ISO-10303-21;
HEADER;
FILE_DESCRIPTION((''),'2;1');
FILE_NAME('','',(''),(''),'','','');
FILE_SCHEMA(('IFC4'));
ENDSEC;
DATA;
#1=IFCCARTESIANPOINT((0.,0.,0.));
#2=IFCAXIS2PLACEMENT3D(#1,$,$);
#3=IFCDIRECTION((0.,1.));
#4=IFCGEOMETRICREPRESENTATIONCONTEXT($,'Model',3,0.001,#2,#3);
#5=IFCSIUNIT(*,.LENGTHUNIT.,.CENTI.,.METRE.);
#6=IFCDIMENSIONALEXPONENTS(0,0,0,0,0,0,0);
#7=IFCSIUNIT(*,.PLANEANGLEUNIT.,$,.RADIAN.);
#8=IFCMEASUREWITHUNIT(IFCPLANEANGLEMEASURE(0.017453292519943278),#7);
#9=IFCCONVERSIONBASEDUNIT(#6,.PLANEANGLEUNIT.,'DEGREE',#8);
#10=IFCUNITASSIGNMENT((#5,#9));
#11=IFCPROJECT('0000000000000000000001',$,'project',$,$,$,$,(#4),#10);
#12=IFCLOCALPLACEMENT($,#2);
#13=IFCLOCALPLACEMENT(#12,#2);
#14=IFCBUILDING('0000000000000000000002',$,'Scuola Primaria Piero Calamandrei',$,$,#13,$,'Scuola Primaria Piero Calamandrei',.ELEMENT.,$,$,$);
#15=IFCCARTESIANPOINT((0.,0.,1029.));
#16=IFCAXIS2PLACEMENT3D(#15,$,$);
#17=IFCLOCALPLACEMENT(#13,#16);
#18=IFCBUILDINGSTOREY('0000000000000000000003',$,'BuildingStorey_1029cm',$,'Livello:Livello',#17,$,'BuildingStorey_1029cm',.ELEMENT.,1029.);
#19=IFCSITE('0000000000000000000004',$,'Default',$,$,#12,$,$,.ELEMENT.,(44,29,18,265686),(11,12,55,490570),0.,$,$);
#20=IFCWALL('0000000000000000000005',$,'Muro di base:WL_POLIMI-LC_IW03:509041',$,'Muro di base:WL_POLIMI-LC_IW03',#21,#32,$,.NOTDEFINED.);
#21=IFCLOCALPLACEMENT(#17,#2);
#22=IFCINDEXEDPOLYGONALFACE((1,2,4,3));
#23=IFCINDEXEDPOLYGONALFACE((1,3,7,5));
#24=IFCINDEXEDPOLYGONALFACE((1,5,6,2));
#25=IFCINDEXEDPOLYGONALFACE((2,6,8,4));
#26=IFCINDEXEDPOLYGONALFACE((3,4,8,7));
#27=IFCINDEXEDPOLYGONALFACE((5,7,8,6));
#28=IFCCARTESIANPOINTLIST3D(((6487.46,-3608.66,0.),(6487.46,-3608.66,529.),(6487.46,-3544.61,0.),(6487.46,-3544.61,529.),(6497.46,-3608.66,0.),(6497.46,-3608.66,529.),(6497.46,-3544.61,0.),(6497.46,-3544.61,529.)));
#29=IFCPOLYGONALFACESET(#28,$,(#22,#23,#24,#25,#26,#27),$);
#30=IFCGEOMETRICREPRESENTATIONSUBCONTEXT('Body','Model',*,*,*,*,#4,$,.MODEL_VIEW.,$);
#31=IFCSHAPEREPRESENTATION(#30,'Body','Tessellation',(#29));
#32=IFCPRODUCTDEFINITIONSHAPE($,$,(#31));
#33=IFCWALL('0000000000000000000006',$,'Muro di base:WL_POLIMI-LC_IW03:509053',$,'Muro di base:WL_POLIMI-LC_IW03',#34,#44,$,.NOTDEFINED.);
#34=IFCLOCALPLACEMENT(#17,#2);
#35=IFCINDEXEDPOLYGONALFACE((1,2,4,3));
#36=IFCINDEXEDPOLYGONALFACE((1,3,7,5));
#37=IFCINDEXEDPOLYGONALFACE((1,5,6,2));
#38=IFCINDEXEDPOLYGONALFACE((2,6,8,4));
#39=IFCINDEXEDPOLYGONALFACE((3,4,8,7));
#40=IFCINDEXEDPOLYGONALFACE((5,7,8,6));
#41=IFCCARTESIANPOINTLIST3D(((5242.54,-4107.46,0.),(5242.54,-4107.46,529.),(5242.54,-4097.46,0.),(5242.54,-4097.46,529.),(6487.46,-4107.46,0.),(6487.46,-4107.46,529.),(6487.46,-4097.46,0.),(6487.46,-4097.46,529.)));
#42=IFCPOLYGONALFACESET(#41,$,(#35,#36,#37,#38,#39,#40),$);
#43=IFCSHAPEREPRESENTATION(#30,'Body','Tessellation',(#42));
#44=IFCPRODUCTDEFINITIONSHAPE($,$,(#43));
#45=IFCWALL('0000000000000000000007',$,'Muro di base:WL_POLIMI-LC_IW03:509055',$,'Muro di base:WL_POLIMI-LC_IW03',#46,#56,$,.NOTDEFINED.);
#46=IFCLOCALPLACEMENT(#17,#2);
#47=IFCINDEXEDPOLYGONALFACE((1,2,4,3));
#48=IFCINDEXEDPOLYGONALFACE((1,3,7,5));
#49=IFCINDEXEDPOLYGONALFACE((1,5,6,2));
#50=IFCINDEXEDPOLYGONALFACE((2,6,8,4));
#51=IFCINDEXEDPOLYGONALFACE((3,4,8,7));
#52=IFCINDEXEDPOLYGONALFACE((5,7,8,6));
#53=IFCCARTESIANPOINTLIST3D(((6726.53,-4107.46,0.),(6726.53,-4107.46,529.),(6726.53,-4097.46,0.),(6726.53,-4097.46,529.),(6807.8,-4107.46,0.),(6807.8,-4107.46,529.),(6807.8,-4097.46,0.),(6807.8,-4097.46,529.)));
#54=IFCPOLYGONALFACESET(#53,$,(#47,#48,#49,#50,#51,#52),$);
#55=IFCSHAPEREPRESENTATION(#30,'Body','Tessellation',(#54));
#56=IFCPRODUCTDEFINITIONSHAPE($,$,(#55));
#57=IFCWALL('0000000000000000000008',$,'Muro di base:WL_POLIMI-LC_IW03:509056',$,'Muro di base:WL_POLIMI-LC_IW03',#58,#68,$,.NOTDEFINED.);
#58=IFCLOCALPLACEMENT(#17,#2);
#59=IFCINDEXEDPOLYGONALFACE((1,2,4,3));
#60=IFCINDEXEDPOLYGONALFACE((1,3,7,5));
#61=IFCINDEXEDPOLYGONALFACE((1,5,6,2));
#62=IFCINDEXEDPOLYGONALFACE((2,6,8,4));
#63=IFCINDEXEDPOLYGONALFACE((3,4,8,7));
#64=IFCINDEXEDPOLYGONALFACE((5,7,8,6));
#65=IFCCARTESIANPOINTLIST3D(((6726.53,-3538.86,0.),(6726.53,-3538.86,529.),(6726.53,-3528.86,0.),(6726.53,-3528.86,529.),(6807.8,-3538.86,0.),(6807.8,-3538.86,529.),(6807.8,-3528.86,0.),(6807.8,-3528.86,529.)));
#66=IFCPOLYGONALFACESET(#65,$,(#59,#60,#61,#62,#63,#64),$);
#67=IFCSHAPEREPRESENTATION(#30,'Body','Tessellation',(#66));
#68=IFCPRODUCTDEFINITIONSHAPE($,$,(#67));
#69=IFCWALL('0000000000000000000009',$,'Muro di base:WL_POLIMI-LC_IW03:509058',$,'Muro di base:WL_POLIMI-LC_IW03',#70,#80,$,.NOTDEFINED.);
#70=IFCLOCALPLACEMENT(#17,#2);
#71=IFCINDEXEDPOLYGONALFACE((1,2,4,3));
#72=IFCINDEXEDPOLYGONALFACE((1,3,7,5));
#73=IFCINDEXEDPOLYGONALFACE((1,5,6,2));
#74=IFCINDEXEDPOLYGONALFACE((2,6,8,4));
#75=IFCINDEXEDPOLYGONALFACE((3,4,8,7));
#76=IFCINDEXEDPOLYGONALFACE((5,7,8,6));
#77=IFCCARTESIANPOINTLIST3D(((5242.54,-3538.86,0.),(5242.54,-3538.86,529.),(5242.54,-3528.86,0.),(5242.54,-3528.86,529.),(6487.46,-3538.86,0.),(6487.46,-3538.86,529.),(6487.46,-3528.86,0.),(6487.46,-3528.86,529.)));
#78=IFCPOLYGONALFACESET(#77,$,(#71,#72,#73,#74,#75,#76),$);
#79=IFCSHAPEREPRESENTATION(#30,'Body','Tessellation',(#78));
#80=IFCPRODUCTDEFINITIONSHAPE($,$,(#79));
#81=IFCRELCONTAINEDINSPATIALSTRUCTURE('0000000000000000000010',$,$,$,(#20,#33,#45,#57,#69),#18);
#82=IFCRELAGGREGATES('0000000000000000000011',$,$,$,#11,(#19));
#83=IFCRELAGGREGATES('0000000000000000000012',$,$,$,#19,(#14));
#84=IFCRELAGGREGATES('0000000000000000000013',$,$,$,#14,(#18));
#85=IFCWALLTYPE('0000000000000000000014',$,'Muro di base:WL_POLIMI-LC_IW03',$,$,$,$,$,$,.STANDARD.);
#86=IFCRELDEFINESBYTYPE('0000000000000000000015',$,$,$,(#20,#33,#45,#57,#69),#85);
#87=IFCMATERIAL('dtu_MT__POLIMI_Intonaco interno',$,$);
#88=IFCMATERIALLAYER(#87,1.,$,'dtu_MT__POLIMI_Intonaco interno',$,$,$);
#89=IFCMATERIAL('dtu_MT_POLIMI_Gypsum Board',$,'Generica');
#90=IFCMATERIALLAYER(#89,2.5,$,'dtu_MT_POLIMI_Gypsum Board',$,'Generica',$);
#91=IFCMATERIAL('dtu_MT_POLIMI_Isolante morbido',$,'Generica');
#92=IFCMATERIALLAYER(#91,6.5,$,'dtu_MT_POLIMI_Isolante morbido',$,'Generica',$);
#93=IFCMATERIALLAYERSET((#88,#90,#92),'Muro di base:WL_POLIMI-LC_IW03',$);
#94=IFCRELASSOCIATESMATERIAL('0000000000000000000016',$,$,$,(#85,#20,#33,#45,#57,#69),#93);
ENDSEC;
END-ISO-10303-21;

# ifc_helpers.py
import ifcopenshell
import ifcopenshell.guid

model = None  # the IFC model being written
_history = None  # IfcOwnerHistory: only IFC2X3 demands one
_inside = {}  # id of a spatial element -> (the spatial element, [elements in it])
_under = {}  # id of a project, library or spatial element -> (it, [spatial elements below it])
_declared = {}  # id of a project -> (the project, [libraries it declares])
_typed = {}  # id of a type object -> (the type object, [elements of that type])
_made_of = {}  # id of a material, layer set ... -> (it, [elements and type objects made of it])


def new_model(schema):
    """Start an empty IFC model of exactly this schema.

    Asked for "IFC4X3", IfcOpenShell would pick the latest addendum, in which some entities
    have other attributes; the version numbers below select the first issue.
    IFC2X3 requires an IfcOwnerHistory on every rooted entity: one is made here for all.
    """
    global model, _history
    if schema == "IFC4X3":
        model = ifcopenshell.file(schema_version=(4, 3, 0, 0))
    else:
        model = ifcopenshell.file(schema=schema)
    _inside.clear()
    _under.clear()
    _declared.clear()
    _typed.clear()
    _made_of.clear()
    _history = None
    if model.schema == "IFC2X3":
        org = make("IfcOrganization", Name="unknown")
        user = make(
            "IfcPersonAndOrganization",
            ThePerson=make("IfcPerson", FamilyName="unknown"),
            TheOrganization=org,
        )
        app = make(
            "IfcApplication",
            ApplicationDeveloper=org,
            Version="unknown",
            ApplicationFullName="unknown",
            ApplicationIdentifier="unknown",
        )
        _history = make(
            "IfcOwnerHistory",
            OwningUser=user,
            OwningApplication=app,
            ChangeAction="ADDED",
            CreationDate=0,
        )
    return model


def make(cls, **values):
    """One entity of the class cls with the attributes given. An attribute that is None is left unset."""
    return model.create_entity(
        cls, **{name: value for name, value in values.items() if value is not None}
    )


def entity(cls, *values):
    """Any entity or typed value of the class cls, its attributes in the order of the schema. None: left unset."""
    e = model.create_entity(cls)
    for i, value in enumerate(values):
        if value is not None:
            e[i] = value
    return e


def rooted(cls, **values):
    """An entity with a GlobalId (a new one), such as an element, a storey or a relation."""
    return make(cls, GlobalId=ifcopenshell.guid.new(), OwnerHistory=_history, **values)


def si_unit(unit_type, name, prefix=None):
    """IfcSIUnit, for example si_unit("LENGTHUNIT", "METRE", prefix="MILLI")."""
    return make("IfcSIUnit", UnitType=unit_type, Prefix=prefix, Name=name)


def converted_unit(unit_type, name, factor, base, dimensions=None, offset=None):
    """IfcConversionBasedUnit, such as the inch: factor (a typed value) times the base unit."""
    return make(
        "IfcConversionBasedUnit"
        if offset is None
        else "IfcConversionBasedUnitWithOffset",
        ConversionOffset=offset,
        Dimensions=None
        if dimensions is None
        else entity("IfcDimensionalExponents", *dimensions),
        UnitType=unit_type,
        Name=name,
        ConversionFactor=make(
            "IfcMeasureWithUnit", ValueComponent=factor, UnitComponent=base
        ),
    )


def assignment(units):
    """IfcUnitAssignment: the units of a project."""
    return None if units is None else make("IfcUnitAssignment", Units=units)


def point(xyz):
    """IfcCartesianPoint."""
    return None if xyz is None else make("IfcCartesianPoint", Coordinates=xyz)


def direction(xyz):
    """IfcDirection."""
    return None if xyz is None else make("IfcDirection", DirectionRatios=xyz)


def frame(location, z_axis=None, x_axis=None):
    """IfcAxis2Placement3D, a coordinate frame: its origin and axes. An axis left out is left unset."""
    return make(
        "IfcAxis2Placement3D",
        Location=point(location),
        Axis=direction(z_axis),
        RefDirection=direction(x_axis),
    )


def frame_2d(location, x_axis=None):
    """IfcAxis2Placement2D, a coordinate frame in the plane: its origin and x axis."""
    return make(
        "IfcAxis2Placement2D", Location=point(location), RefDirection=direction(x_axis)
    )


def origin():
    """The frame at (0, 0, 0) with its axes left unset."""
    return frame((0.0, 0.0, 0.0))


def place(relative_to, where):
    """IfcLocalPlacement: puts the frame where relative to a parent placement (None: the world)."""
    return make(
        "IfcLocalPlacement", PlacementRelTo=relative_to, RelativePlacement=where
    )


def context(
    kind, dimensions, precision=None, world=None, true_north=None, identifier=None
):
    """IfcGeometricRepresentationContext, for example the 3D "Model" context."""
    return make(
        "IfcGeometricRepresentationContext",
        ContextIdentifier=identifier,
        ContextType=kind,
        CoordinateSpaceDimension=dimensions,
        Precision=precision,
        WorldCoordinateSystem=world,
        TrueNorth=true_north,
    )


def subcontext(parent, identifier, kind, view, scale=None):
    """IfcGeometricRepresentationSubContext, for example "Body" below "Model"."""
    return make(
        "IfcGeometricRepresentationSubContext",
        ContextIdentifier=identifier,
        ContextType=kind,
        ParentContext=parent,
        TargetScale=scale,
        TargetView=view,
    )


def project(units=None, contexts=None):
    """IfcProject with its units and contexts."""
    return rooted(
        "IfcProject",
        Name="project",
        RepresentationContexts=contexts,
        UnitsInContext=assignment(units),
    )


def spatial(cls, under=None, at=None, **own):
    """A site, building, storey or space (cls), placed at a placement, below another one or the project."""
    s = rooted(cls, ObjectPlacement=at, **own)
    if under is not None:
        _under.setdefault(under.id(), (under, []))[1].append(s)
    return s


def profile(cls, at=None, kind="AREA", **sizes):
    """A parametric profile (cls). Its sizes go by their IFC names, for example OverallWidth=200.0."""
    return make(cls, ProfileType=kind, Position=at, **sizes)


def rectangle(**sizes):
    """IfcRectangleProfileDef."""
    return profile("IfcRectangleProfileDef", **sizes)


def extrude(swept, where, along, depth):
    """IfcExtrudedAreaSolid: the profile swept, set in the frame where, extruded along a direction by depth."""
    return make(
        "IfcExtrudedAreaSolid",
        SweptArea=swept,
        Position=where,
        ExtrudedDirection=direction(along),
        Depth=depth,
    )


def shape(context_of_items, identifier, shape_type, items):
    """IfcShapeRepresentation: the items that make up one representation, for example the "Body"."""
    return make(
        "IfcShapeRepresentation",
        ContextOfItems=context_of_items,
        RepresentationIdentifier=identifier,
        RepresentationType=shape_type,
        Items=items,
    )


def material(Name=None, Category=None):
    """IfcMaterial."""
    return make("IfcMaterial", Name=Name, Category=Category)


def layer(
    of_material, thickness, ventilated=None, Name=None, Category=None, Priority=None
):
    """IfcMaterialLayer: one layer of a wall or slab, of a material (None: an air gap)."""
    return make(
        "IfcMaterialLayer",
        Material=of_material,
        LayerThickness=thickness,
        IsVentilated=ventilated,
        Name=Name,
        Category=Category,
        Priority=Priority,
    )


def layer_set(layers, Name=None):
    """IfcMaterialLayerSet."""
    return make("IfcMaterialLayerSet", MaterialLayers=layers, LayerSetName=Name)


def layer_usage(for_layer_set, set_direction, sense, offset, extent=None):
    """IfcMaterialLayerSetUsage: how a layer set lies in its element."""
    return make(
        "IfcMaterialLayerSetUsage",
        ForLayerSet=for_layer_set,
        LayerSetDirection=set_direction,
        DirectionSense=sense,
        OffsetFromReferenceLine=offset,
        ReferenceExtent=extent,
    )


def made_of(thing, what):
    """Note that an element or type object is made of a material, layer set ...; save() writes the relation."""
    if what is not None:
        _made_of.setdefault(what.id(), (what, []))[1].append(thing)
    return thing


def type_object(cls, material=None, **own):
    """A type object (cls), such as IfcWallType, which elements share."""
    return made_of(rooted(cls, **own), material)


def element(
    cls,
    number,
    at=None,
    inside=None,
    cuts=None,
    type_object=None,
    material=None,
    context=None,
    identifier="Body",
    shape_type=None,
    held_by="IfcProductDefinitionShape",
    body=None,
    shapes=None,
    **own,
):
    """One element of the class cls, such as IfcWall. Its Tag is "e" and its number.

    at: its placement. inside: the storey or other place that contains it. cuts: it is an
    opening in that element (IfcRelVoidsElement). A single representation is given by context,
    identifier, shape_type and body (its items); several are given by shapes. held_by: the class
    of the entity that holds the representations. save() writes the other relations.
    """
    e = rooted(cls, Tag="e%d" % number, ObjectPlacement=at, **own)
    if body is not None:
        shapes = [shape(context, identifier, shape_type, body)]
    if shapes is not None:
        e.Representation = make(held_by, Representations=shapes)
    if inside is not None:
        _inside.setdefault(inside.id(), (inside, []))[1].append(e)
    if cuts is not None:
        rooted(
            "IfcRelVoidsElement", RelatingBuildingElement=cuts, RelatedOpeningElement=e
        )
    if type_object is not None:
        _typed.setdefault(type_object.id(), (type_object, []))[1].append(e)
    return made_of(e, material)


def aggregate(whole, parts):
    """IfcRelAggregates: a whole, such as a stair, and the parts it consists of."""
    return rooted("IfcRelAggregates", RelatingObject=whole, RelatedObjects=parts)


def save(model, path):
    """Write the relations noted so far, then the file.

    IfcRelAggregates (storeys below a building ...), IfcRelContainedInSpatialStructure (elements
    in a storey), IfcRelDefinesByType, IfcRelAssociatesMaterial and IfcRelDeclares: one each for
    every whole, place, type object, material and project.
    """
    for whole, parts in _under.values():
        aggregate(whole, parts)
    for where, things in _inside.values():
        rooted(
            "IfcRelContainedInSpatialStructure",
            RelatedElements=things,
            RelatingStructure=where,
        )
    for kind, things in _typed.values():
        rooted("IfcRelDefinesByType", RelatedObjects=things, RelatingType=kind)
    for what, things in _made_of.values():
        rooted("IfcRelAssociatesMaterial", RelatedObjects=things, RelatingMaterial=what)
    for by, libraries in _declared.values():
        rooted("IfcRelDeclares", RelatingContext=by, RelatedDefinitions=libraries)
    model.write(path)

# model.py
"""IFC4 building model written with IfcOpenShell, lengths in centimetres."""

from ifc_helpers import new_model, entity, si_unit, converted_unit, direction, frame, frame_2d, origin, place, context, subcontext, project, spatial, rectangle, extrude, material, layer, layer_set, layer_usage, type_object, element, save


model = new_model("IFC4")

# Units and contexts
model_context = context("Model", 3, precision=0.001, world=origin(), true_north=direction((0.0, 1.0)))
body_context = subcontext(model_context, "Body", "Model", "MODEL_VIEW")
ifc_project = project(units=[si_unit("LENGTHUNIT", "METRE", prefix="CENTI"), converted_unit("PLANEANGLEUNIT", "DEGREE", entity("IfcPlaneAngleMeasure", 0.017453292519943278), si_unit("PLANEANGLEUNIT", "RADIAN"), dimensions=[0, 0, 0, 0, 0, 0, 0])], contexts=[model_context])

# Site, building, storey
site_placement = place(None, origin())
site = spatial("IfcSite", under=ifc_project, at=site_placement, Name="Default", CompositionType="ELEMENT", RefLatitude=(44, 29, 18, 265686), RefLongitude=(11, 12, 55, 490570), RefElevation=0.0)
building_placement = place(site_placement, origin())
building = spatial("IfcBuilding", under=site, at=building_placement, Name="Scuola Primaria Piero Calamandrei", LongName="Scuola Primaria Piero Calamandrei", CompositionType="ELEMENT")
storey_placement = place(building_placement, frame((0.0, 0.0, 1029.0)))
storey = spatial("IfcBuildingStorey", under=building, at=storey_placement, Name="BuildingStorey_1029cm", ObjectType="Livello:Livello", LongName="BuildingStorey_1029cm", CompositionType="ELEMENT", Elevation=1029.0)

# Shared definitions
ifc_material_1 = material(Name="dtu_MT_POLIMI_Isolante morbido", Category="Generica")
ifc_material_2 = material(Name="dtu_MT_POLIMI_Gypsum Board", Category="Generica")
ifc_material_3 = material(Name="dtu_MT__POLIMI_Intonaco interno")

# Walls
ifc_layer_1 = layer(ifc_material_3, 1.0, Name="dtu_MT__POLIMI_Intonaco interno")
ifc_layer_2 = layer(ifc_material_2, 2.5, Name="dtu_MT_POLIMI_Gypsum Board", Category="Generica")
ifc_layer_3 = layer(ifc_material_1, 6.5, Name="dtu_MT_POLIMI_Isolante morbido", Category="Generica")
ifc_layer_set_1 = layer_set([ifc_layer_1, ifc_layer_2, ifc_layer_3], Name="Muro di base:WL_POLIMI-LC_IW03")
wall_type_1 = type_object("IfcWallType", Name="Muro di base:WL_POLIMI-LC_IW03", PredefinedType="STANDARD", material=ifc_layer_set_1)
ifc_layer_usage_1 = layer_usage(ifc_layer_set_1, "AXIS2", "NEGATIVE", 5.0)
wall_1_placement = place(storey_placement, frame((6492.46, -3608.66, 0.0), z_axis=(0.0, 0.0, 1.0), x_axis=(0.0, 1.0, 0.0)))
element("IfcWall", 1, at=wall_1_placement, inside=storey, type_object=wall_type_1, material=ifc_layer_usage_1, Name="Muro di base:WL_POLIMI-LC_IW03:509041", ObjectType="Muro di base:WL_POLIMI-LC_IW03", PredefinedType="NOTDEFINED", context=body_context, shape_type="SweptSolid", body=[
    extrude(rectangle(XDim=64.05, YDim=10.0, at=frame_2d((32.03, 0.0), x_axis=(-1.0, 0.0))), origin(), (0.0, 0.0, 1.0), 529.0),
])
ifc_layer_usage_2 = layer_usage(ifc_layer_set_1, "AXIS2", "NEGATIVE", 5.0)
wall_2_placement = place(storey_placement, frame((5242.54, -4102.46, 0.0)))
element("IfcWall", 2, at=wall_2_placement, inside=storey, type_object=wall_type_1, material=ifc_layer_usage_2, Name="Muro di base:WL_POLIMI-LC_IW03:509053", ObjectType="Muro di base:WL_POLIMI-LC_IW03", PredefinedType="NOTDEFINED", context=body_context, shape_type="SweptSolid", body=[
    extrude(rectangle(XDim=1244.91, YDim=10.0, at=frame_2d((622.46, 0.0), x_axis=(-1.0, 0.0))), origin(), (0.0, 0.0, 1.0), 529.0),
])
ifc_layer_usage_3 = layer_usage(ifc_layer_set_1, "AXIS2", "NEGATIVE", 5.0)
wall_3_placement = place(storey_placement, frame((6726.53, -4102.46, 0.0)))
element("IfcWall", 3, at=wall_3_placement, inside=storey, type_object=wall_type_1, material=ifc_layer_usage_3, Name="Muro di base:WL_POLIMI-LC_IW03:509055", ObjectType="Muro di base:WL_POLIMI-LC_IW03", PredefinedType="NOTDEFINED", context=body_context, shape_type="SweptSolid", body=[
    extrude(rectangle(XDim=81.27, YDim=10.0, at=frame_2d((40.64, 0.0), x_axis=(-1.0, 0.0))), origin(), (0.0, 0.0, 1.0), 529.0),
])
ifc_layer_usage_4 = layer_usage(ifc_layer_set_1, "AXIS2", "NEGATIVE", 5.0)
wall_4_placement = place(storey_placement, frame((6726.53, -3533.86, 0.0)))
element("IfcWall", 4, at=wall_4_placement, inside=storey, type_object=wall_type_1, material=ifc_layer_usage_4, Name="Muro di base:WL_POLIMI-LC_IW03:509056", ObjectType="Muro di base:WL_POLIMI-LC_IW03", PredefinedType="NOTDEFINED", context=body_context, shape_type="SweptSolid", body=[
    extrude(rectangle(XDim=81.27, YDim=10.0, at=frame_2d((40.64, 0.0), x_axis=(-1.0, 0.0))), origin(), (0.0, 0.0, 1.0), 529.0),
])
ifc_layer_usage_5 = layer_usage(ifc_layer_set_1, "AXIS2", "NEGATIVE", 5.0)
wall_5_placement = place(storey_placement, frame((6487.46, -3533.86, 0.0), z_axis=(0.0, 0.0, 1.0), x_axis=(-1.0, 0.0, 0.0)))
element("IfcWall", 5, at=wall_5_placement, inside=storey, type_object=wall_type_1, material=ifc_layer_usage_5, Name="Muro di base:WL_POLIMI-LC_IW03:509058", ObjectType="Muro di base:WL_POLIMI-LC_IW03", PredefinedType="NOTDEFINED", context=body_context, shape_type="SweptSolid", body=[
    extrude(rectangle(XDim=1244.91, YDim=10.0, at=frame_2d((622.46, 0.0), x_axis=(-1.0, 0.0))), origin(), (0.0, 0.0, 1.0), 529.0),
])

save(model, "model.ifc")
